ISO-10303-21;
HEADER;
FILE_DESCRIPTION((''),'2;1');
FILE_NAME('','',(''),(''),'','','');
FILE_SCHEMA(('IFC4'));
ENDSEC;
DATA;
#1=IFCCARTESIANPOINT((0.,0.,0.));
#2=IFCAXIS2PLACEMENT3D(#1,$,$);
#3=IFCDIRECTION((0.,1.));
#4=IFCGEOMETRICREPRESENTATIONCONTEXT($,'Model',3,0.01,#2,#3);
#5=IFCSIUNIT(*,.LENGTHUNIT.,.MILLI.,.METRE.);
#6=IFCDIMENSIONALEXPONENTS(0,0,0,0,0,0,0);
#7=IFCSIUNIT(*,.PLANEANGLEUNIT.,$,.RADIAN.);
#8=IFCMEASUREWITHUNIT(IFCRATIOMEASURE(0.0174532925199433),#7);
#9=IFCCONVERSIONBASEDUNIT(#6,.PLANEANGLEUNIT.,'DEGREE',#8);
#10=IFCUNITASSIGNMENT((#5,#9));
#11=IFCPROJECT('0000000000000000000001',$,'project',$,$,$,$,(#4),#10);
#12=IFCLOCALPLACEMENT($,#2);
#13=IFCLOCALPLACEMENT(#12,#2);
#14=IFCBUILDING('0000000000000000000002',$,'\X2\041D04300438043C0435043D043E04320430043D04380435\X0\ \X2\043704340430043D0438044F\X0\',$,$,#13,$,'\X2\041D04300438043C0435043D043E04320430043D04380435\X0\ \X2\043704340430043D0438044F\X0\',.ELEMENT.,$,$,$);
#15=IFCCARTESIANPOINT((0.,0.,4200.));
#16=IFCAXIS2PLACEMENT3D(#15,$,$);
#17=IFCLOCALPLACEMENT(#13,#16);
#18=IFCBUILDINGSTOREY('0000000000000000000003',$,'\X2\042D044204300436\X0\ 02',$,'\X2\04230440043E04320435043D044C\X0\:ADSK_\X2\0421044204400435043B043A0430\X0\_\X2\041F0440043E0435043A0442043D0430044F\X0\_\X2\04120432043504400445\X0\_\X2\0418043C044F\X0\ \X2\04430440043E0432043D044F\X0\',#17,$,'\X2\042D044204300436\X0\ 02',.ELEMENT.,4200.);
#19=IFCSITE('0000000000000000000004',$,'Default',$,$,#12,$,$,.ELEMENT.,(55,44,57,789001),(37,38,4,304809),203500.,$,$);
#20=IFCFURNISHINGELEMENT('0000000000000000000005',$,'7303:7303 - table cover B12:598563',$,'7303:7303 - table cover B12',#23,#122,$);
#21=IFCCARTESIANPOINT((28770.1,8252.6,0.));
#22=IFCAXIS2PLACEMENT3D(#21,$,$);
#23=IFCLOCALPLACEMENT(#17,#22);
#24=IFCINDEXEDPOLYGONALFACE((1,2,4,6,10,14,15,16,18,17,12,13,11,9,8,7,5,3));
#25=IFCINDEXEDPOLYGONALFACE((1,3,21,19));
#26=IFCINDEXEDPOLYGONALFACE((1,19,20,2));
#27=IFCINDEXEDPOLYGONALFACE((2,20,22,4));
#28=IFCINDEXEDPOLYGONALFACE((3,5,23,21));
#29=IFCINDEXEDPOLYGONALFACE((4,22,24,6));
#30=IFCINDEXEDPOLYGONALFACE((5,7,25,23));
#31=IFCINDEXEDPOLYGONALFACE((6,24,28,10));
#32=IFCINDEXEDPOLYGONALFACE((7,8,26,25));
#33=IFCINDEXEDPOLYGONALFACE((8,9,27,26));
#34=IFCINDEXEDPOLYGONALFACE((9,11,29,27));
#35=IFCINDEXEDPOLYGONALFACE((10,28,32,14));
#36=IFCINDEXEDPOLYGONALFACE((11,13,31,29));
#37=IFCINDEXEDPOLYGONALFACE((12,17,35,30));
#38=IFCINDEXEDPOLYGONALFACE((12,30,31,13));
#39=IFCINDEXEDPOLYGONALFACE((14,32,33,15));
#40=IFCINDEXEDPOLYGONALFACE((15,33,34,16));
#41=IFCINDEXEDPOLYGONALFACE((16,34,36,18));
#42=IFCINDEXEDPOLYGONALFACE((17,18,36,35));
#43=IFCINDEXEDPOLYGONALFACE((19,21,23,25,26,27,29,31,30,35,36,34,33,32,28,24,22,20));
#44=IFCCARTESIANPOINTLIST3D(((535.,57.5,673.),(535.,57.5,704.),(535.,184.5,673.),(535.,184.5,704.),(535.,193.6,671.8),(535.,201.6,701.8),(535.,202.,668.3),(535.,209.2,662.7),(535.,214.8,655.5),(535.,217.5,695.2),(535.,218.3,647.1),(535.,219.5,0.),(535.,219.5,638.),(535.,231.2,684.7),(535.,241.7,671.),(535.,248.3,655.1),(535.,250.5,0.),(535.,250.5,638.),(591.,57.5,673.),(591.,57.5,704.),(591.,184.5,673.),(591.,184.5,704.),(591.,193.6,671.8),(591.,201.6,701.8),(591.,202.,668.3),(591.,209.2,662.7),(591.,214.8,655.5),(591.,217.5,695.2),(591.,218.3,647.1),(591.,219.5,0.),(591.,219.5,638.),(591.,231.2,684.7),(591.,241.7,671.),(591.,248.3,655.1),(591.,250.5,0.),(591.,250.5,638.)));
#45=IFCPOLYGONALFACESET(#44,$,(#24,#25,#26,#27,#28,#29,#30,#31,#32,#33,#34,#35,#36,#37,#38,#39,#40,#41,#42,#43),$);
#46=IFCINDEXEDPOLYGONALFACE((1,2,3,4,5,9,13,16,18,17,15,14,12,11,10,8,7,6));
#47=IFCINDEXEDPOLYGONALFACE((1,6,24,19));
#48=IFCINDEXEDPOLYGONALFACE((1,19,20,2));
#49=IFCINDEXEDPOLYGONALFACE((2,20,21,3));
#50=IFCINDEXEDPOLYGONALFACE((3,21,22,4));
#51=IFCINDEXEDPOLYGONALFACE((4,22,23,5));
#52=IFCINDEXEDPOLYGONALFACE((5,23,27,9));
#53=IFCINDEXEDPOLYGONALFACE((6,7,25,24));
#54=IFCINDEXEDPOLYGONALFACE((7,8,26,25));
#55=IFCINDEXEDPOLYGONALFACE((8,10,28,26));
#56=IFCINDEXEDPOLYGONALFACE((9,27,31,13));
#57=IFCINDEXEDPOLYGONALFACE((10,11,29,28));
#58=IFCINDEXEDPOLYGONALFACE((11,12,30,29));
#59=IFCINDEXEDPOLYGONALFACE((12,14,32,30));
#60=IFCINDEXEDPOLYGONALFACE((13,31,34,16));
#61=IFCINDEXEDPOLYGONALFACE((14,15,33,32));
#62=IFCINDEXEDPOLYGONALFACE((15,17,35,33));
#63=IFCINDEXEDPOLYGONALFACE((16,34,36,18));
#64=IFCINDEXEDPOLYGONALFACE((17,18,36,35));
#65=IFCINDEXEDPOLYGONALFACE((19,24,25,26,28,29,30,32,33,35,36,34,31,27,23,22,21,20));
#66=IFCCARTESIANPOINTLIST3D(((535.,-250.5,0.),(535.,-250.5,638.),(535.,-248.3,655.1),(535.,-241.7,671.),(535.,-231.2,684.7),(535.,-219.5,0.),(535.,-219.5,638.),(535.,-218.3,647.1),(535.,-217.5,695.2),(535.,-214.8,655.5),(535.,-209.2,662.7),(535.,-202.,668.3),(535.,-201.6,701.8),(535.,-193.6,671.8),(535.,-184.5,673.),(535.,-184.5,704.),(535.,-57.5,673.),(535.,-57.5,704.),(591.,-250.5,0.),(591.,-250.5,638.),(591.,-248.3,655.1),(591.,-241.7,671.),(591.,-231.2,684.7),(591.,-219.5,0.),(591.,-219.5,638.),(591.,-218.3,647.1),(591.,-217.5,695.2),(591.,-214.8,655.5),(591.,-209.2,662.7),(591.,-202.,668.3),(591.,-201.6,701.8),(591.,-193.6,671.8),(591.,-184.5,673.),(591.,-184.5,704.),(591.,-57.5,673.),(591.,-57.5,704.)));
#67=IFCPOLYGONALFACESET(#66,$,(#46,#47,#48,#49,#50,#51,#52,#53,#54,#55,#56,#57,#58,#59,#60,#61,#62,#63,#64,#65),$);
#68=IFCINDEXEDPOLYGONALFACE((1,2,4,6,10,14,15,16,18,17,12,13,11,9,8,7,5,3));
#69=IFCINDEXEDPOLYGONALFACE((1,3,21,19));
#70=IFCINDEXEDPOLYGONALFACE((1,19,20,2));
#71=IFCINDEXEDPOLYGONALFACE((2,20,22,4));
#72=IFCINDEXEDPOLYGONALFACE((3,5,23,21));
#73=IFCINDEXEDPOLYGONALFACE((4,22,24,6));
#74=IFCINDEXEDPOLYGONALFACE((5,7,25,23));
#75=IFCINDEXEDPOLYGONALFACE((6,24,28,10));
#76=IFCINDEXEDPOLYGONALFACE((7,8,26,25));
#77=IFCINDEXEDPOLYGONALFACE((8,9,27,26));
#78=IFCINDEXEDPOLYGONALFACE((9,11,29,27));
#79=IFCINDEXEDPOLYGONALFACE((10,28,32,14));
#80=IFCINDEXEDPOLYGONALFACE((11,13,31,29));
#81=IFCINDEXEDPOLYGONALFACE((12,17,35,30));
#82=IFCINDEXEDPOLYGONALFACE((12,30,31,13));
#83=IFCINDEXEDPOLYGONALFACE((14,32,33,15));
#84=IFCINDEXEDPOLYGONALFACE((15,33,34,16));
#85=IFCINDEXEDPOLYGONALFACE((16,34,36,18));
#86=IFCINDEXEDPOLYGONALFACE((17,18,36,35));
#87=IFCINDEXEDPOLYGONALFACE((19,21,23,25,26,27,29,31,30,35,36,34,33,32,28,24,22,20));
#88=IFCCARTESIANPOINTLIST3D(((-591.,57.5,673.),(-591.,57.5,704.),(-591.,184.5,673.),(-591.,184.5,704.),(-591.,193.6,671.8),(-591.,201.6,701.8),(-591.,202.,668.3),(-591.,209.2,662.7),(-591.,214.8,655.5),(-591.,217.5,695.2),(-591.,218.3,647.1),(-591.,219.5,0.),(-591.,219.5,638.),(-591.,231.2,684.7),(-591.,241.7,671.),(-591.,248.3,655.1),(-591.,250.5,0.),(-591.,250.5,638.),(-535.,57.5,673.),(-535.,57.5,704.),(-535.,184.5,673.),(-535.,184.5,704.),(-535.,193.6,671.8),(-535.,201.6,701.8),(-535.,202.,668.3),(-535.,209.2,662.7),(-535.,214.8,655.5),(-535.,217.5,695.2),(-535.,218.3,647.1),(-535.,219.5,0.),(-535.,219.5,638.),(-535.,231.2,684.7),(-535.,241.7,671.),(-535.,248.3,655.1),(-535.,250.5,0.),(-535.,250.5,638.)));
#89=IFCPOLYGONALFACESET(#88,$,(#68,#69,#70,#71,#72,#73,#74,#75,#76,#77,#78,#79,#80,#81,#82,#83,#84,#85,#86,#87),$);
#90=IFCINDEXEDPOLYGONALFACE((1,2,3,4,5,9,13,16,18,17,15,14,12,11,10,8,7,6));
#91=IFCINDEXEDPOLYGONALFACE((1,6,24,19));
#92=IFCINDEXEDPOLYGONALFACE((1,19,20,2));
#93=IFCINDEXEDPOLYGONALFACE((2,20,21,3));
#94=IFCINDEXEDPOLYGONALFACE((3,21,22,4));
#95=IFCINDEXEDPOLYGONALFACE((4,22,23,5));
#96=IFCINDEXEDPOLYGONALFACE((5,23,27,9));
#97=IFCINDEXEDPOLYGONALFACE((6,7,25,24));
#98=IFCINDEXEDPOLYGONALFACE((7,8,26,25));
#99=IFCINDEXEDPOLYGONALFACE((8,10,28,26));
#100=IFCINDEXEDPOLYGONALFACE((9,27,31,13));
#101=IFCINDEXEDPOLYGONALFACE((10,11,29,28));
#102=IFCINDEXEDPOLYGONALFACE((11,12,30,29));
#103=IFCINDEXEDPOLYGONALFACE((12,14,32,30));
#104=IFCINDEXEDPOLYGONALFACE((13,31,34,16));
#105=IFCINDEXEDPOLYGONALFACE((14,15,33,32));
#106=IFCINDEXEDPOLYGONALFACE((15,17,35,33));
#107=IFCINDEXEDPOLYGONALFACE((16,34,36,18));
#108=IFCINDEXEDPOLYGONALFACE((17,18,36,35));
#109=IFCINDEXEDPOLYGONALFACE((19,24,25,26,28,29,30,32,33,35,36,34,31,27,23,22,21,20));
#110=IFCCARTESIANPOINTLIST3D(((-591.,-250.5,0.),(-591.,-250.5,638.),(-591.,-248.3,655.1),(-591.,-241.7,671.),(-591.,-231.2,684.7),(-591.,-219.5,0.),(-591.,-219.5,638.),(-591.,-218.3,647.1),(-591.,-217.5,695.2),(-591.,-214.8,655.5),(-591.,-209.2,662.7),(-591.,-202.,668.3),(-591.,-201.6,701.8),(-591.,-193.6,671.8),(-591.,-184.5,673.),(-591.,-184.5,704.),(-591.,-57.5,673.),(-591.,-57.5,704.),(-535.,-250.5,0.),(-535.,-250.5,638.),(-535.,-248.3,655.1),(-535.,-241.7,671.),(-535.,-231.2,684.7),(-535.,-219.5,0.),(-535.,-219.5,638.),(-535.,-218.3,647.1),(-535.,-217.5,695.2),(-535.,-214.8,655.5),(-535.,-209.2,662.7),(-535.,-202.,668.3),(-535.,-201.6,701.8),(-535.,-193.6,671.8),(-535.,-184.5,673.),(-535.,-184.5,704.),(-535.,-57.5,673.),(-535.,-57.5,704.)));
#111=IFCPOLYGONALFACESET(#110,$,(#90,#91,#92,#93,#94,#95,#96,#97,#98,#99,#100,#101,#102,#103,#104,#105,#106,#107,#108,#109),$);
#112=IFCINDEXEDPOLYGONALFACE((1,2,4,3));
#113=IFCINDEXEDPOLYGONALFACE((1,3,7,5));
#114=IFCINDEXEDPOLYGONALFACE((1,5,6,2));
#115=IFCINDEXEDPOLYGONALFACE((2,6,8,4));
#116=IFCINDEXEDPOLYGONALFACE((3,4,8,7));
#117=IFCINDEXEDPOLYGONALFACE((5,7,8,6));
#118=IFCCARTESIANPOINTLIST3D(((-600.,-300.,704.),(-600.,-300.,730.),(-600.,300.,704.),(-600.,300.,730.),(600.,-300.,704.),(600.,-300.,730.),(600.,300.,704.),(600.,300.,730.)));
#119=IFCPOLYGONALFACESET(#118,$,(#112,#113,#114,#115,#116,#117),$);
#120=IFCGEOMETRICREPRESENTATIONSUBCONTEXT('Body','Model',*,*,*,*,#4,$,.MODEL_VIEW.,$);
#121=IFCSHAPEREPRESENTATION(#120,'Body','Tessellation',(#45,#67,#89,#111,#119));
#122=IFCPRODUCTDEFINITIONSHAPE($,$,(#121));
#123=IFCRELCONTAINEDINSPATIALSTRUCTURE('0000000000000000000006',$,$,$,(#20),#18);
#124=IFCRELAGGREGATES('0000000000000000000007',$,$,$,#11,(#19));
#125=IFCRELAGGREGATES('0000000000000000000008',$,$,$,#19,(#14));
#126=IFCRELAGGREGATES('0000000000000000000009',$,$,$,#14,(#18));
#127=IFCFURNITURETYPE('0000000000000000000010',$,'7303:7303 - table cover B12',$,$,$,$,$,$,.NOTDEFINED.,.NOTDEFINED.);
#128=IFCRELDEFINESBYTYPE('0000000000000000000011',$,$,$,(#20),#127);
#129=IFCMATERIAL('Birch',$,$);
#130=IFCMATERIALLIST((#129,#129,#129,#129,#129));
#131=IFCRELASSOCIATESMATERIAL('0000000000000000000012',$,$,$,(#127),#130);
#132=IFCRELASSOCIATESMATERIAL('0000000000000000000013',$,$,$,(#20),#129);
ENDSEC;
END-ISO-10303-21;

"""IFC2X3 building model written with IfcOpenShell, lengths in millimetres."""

from ifc_helpers import new_model, entity, si_unit, converted_unit, direction, frame, frame_2d, origin, origin_2d_with_axis, place, context, subcontext, project, spatial, polyline, circle_curve, parameter, trimmed, segment, composite_curve, rectangle, outline, extrude, source, transform, mapped, material, material_list, type_object, type_shapes, element, save


model = new_model("IFC2X3")

# Units and contexts
model_context = context("Model", 3, precision=0.01, world=origin(), true_north=direction((0.0, 1.0)))
body_context = subcontext(model_context, "Body", "Model", "MODEL_VIEW")
ifc_project = project(units=[si_unit("LENGTHUNIT", "METRE", prefix="MILLI"), converted_unit("PLANEANGLEUNIT", "DEGREE", entity("IfcRatioMeasure", 0.0174532925199433), si_unit("PLANEANGLEUNIT", "RADIAN"), dimensions=[0, 0, 0, 0, 0, 0, 0])], contexts=[model_context])

# Site, building, storey
site_placement = place(None, origin())
site = spatial("IfcSite", under=ifc_project, at=site_placement, Name="Default", CompositionType="ELEMENT", RefLatitude=(55, 44, 57, 789001), RefLongitude=(37, 38, 4, 304809), RefElevation=203500.0)
building_placement = place(site_placement, origin())
building = spatial("IfcBuilding", under=site, at=building_placement, Name="Наименование здания", LongName="Наименование здания", CompositionType="ELEMENT")
storey_placement = place(building_placement, frame((0.0, 0.0, 4200.0)))
storey = spatial("IfcBuildingStorey", under=building, at=storey_placement, Name="Этаж 02", ObjectType="Уровень:ADSK_Стрелка_Проектная_Вверх_Имя уровня", LongName="Этаж 02", CompositionType="ELEMENT", Elevation=4200.0)

# Furnishing element
ifc_material_1 = material(Name="Birch")
ifc_material_list_1 = material_list([ifc_material_1, ifc_material_1, ifc_material_1, ifc_material_1, ifc_material_1])
furniture_type_1 = type_object("IfcFurnitureType", Name="7303:7303 - table cover B12", material=ifc_material_list_1)
shared_shape_1 = source(origin(), body_context, "Body", "SweptSolid", [
    extrude(outline(composite_curve([segment(polyline([(-200.2, -120.5), (-169.2, -120.5)]), True, "CONTINUOUS"), segment(polyline([(-169.2, -120.5), (-169.2, 6.5)]), True, "CONTINUOUS"), segment(trimmed(circle_curve(frame_2d((-134.2, 6.5), x_axis=(0.0, -1.0)), 35.0), [parameter(180.0)], [parameter(270.0)], True, "PARAMETER"), False, "CONTINUOUS"), segment(polyline([(-134.2, 41.5), (503.8, 41.5)]), True, "CONTINUOUS"), segment(polyline([(503.8, 41.5), (503.8, 72.5)]), True, "CONTINUOUS"), segment(polyline([(503.8, 72.5), (-134.2, 72.5)]), True, "CONTINUOUS"), segment(trimmed(circle_curve(frame_2d((-134.2, 6.5), x_axis=(0.0, -1.0)), 66.0), [parameter(180.0)], [parameter(270.0)], True, "PARAMETER"), True, "CONTINUOUS"), segment(polyline([(-200.2, 6.5), (-200.2, -120.5)]), True, "CONTINUOUS")], self_intersect=False)), frame((535.0, 178.0, 503.8), z_axis=(1.0, 0.0, 0.0), x_axis=(0.0, 0.0, -1.0)), (0.0, 0.0, 1.0), 56.0),
    extrude(outline(composite_curve([segment(polyline([(-120.5, -200.2), (6.5, -200.2)]), True, "CONTINUOUS"), segment(trimmed(circle_curve(frame_2d((6.5, -134.2), x_axis=(-1.0, 0.0)), 66.0), [parameter(90.0)], [parameter(180.0)], True, "PARAMETER"), True, "CONTINUOUS"), segment(polyline([(72.5, -134.2), (72.5, 503.8)]), True, "CONTINUOUS"), segment(polyline([(72.5, 503.8), (41.5, 503.8)]), True, "CONTINUOUS"), segment(polyline([(41.5, 503.8), (41.5, -134.2)]), True, "CONTINUOUS"), segment(trimmed(circle_curve(frame_2d((6.5, -134.2), x_axis=(-1.0, 0.0)), 35.0), [parameter(90.0)], [parameter(180.0)], True, "PARAMETER"), False, "CONTINUOUS"), segment(polyline([(6.5, -169.2), (-120.5, -169.2)]), True, "CONTINUOUS"), segment(polyline([(-120.5, -169.2), (-120.5, -200.2)]), True, "CONTINUOUS")], self_intersect=False)), frame((535.0, -178.0, 503.8), z_axis=(1.0, 0.0, 0.0), x_axis=(0.0, -1.0, 0.0)), (0.0, 0.0, 1.0), 56.0),
    extrude(outline(composite_curve([segment(polyline([(-200.2, -120.5), (-169.2, -120.5)]), True, "CONTINUOUS"), segment(polyline([(-169.2, -120.5), (-169.2, 6.5)]), True, "CONTINUOUS"), segment(trimmed(circle_curve(frame_2d((-134.2, 6.5), x_axis=(0.0, -1.0)), 35.0), [parameter(180.0)], [parameter(270.0)], True, "PARAMETER"), False, "CONTINUOUS"), segment(polyline([(-134.2, 41.5), (503.8, 41.5)]), True, "CONTINUOUS"), segment(polyline([(503.8, 41.5), (503.8, 72.5)]), True, "CONTINUOUS"), segment(polyline([(503.8, 72.5), (-134.2, 72.5)]), True, "CONTINUOUS"), segment(trimmed(circle_curve(frame_2d((-134.2, 6.5), x_axis=(0.0, -1.0)), 66.0), [parameter(180.0)], [parameter(270.0)], True, "PARAMETER"), True, "CONTINUOUS"), segment(polyline([(-200.2, 6.5), (-200.2, -120.5)]), True, "CONTINUOUS")], self_intersect=False)), frame((-591.0, 178.0, 503.8), z_axis=(1.0, 0.0, 0.0), x_axis=(0.0, 0.0, -1.0)), (0.0, 0.0, 1.0), 56.0),
    extrude(outline(composite_curve([segment(polyline([(-120.5, -200.2), (6.5, -200.2)]), True, "CONTINUOUS"), segment(trimmed(circle_curve(frame_2d((6.5, -134.2), x_axis=(-1.0, 0.0)), 66.0), [parameter(90.0)], [parameter(180.0)], True, "PARAMETER"), True, "CONTINUOUS"), segment(polyline([(72.5, -134.2), (72.5, 503.8)]), True, "CONTINUOUS"), segment(polyline([(72.5, 503.8), (41.5, 503.8)]), True, "CONTINUOUS"), segment(polyline([(41.5, 503.8), (41.5, -134.2)]), True, "CONTINUOUS"), segment(trimmed(circle_curve(frame_2d((6.5, -134.2), x_axis=(-1.0, 0.0)), 35.0), [parameter(90.0)], [parameter(180.0)], True, "PARAMETER"), False, "CONTINUOUS"), segment(polyline([(6.5, -169.2), (-120.5, -169.2)]), True, "CONTINUOUS"), segment(polyline([(-120.5, -169.2), (-120.5, -200.2)]), True, "CONTINUOUS")], self_intersect=False)), frame((-591.0, -178.0, 503.8), z_axis=(1.0, 0.0, 0.0), x_axis=(0.0, -1.0, 0.0)), (0.0, 0.0, 1.0), 56.0),
    extrude(rectangle(XDim=1200.0, YDim=600.0, at=origin_2d_with_axis()), frame((0.0, 0.0, 704.0), z_axis=(0.0, 0.0, 1.0), x_axis=(-1.0, 0.0, 0.0)), (0.0, 0.0, 1.0), 26.0),
])
type_shapes(furniture_type_1, [shared_shape_1])
furnishing_1_placement = place(storey_placement, frame((28770.1, 8252.6, 0.0)))
element("IfcFurnishingElement", 1, at=furnishing_1_placement, inside=storey, type_object=furniture_type_1, material=ifc_material_1, Name="7303:7303 - table cover B12:598563", ObjectType="7303:7303 - table cover B12", context=body_context, shape_type="MappedRepresentation", body=[
    mapped(shared_shape_1, transform((0.0, 0.0, 0.0), scale=1.0)),
])

save(model, "model.ifc")
